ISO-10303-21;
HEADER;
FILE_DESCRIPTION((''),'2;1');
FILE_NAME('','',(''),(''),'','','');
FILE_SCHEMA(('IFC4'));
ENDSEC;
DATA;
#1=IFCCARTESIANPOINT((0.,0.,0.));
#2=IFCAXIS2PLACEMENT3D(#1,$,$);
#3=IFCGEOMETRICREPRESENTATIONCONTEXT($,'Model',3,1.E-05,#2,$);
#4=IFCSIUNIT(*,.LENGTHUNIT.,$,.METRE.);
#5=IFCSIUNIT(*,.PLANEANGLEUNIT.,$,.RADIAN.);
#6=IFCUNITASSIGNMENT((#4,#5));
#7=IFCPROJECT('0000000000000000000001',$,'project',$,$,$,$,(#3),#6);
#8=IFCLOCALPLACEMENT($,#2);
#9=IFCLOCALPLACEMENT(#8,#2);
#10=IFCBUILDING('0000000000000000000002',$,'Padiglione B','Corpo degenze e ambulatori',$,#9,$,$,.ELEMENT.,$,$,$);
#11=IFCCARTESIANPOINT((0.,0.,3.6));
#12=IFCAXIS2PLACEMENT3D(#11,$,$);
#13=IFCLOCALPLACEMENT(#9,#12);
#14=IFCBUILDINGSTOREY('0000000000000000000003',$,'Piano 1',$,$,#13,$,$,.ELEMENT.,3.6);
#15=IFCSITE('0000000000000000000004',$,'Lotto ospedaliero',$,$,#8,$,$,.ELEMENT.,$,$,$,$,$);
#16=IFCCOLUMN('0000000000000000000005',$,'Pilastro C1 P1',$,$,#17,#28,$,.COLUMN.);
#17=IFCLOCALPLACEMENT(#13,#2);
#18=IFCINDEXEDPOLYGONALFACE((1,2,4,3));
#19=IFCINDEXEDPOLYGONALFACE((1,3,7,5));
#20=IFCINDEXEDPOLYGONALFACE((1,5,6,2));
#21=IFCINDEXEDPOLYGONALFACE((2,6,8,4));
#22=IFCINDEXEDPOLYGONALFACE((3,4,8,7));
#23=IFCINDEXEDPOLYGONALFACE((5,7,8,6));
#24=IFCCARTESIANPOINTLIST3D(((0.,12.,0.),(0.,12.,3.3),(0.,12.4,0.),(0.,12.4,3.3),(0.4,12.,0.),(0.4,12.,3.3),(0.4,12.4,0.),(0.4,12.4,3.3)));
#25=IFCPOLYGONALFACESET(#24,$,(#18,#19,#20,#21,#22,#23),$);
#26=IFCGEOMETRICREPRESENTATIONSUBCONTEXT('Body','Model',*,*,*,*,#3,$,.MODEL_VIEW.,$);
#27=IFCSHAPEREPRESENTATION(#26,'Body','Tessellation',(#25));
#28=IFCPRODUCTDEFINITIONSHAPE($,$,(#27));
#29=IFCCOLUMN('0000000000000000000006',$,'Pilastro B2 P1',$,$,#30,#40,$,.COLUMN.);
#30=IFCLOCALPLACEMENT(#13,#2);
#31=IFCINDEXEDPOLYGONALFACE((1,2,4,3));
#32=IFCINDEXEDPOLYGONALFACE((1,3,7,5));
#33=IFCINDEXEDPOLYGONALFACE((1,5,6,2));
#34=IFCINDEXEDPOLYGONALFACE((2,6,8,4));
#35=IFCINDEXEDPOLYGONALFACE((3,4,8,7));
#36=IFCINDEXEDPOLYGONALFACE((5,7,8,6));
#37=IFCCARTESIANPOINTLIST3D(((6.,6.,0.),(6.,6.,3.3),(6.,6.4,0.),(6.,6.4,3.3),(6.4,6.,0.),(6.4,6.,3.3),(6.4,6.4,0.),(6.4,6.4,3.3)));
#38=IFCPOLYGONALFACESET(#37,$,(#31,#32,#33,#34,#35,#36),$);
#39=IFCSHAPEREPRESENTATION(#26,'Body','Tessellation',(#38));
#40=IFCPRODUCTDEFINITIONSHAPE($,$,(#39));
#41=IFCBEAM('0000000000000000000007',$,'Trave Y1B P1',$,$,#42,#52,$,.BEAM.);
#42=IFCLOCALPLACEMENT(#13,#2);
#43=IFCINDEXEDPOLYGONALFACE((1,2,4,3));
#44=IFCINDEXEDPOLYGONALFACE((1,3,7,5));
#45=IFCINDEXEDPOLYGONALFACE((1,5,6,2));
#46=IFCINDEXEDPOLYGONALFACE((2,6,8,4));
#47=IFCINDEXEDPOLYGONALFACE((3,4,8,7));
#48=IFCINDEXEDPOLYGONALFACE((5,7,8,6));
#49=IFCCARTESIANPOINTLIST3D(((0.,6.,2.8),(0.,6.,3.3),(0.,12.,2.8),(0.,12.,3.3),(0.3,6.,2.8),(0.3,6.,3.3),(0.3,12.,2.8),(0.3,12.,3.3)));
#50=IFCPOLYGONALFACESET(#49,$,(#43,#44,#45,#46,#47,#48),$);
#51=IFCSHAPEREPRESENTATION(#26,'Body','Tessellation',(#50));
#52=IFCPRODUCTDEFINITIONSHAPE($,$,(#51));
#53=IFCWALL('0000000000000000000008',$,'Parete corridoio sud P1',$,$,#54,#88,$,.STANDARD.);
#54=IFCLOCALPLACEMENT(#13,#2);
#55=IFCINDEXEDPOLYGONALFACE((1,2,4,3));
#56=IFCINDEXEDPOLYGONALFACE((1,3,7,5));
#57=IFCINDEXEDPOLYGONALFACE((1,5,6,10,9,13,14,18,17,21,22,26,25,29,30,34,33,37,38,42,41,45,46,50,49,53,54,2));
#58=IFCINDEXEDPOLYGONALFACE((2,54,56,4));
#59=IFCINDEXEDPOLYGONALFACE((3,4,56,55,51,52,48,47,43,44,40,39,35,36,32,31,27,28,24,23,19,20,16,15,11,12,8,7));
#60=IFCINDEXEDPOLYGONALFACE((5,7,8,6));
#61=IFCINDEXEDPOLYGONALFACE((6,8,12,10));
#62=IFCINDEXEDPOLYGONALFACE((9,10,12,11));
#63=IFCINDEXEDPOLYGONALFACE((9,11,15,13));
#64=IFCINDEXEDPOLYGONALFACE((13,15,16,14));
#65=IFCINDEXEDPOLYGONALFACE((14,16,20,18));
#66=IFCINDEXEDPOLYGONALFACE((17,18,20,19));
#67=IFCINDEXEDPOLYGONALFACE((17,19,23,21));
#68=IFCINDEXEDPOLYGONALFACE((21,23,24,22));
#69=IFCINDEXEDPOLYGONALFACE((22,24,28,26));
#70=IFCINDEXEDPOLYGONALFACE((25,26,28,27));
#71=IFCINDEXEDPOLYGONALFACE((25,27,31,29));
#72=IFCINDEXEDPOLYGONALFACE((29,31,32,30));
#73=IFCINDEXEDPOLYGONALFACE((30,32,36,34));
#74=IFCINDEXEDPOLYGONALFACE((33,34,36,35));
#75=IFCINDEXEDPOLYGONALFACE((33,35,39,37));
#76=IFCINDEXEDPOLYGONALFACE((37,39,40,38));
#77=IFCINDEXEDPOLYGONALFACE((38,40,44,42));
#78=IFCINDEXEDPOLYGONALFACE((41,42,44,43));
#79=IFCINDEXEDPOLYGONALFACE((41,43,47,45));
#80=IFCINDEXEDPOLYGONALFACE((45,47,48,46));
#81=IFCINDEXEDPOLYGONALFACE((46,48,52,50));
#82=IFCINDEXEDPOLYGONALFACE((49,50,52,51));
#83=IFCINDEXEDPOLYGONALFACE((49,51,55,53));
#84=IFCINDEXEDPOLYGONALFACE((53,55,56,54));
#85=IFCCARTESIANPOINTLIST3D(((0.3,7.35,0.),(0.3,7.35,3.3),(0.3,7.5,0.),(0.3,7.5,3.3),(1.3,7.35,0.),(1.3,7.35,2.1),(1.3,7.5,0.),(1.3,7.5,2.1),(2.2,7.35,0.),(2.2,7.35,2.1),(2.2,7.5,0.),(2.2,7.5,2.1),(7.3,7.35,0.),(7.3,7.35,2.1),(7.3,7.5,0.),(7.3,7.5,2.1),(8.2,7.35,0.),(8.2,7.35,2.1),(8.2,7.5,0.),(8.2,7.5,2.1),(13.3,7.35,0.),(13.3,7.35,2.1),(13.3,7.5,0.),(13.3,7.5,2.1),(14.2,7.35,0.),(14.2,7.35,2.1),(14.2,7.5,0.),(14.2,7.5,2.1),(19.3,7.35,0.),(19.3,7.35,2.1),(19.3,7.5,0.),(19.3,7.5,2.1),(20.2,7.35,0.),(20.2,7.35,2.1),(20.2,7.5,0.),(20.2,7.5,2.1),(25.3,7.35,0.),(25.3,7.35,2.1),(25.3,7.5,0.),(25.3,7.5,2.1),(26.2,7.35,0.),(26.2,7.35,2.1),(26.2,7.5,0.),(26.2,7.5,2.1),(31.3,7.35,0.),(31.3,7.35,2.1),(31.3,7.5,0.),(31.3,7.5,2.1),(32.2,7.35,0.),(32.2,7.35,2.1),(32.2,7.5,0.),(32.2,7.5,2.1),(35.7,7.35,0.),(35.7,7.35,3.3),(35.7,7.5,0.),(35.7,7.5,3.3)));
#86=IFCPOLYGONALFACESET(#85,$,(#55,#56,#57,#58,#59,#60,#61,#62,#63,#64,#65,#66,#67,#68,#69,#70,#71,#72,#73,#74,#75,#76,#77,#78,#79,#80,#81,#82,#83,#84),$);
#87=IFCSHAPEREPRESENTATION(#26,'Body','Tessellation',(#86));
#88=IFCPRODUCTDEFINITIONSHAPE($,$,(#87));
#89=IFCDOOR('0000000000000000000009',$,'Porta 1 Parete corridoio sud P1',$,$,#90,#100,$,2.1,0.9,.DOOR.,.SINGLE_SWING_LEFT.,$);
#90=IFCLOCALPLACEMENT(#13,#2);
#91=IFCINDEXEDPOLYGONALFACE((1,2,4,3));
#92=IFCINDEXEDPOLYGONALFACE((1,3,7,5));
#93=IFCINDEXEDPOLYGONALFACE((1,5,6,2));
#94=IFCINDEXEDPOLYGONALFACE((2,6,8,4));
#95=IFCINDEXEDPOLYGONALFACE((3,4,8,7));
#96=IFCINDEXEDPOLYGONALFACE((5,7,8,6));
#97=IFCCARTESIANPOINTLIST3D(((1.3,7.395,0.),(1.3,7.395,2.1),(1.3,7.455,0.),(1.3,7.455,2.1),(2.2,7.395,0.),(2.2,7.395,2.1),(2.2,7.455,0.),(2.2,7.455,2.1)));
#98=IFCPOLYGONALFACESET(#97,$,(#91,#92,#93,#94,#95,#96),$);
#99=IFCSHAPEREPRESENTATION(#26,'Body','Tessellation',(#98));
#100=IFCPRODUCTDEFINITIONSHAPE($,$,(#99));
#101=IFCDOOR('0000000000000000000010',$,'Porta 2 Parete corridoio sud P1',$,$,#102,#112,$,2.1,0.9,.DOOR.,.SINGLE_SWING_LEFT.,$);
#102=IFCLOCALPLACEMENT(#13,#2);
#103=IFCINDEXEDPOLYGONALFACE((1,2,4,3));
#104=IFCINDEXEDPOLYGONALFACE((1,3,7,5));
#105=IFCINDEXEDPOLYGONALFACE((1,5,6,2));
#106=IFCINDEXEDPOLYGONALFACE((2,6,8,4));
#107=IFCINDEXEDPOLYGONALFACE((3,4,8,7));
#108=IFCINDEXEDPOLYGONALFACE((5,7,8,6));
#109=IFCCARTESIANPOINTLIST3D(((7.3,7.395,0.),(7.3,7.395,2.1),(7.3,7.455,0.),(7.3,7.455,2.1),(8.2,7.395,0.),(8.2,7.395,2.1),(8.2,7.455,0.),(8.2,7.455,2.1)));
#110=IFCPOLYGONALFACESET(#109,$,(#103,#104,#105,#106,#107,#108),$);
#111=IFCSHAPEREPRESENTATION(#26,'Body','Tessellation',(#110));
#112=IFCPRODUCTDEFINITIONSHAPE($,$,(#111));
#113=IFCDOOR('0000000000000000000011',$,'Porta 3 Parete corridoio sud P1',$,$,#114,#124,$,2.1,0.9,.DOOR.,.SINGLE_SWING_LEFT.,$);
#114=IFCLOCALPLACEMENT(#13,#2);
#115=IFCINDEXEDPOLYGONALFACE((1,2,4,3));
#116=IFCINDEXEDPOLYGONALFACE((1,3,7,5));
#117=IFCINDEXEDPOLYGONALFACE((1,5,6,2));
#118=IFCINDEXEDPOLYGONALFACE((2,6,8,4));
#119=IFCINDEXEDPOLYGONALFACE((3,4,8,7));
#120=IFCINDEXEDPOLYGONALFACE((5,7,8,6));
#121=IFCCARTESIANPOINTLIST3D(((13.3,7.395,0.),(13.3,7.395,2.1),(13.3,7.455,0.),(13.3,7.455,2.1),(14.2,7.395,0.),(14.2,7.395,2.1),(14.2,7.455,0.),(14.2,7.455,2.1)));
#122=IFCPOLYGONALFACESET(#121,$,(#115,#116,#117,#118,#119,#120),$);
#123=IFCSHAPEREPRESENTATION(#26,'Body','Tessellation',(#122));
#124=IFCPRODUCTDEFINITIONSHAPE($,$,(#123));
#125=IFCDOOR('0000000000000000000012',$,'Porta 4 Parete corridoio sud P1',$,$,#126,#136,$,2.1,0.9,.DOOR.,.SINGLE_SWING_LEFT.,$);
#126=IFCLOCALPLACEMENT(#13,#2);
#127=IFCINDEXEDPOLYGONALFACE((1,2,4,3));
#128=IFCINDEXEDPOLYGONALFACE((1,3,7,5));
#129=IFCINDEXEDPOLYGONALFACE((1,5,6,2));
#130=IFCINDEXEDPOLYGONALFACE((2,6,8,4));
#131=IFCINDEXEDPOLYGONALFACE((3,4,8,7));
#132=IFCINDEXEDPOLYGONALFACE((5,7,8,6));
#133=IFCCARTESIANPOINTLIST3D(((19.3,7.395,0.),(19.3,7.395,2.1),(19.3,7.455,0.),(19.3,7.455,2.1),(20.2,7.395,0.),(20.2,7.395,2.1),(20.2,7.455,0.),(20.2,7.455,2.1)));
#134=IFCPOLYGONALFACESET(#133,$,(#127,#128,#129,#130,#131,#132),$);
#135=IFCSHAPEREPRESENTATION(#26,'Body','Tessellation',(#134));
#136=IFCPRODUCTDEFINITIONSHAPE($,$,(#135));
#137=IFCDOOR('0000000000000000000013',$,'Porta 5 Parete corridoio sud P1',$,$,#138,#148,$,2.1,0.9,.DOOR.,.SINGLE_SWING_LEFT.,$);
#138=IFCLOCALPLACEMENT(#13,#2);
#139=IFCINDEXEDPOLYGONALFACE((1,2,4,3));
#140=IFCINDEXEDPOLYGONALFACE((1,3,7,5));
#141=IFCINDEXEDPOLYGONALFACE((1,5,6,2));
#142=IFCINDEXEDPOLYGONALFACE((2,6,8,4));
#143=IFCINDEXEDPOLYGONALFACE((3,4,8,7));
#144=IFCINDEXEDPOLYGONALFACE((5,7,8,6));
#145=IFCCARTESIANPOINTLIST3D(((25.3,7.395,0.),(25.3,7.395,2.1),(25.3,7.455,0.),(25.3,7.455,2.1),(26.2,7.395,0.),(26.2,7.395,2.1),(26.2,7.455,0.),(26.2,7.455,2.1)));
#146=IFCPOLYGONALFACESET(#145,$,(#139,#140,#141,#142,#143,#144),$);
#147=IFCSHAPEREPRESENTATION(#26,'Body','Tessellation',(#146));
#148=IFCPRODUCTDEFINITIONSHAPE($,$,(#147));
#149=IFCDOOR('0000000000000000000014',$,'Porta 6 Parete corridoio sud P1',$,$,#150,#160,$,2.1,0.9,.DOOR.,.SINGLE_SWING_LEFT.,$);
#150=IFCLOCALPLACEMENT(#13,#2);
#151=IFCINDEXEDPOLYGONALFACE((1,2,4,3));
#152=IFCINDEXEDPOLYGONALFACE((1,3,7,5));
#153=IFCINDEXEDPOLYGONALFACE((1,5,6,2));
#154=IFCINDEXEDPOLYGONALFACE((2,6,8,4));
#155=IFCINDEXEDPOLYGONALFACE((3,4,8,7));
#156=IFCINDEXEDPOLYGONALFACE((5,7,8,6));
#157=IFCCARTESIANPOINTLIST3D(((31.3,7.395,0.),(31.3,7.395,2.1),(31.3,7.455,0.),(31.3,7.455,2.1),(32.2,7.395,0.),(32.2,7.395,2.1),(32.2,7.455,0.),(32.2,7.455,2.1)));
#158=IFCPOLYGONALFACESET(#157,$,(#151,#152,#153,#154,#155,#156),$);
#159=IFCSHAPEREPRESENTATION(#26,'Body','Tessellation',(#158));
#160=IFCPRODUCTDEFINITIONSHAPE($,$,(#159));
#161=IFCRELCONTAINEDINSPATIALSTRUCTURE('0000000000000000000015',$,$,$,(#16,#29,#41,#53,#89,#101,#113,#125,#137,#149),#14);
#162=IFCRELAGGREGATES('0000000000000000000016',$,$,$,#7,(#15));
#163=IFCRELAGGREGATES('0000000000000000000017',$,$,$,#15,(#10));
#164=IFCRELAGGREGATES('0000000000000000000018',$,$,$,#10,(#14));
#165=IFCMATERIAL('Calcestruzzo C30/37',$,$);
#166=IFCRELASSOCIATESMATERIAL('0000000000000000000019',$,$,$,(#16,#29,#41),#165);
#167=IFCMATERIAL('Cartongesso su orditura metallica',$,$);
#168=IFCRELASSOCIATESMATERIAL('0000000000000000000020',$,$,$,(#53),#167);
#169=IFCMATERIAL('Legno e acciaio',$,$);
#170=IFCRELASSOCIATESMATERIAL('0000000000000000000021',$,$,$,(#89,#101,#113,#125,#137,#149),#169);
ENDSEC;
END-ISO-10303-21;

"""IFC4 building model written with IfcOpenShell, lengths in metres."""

from ifc_helpers import new_model, si_unit, frame, frame_2d, origin, place, context, subcontext, project, spatial, rectangle, extrude, material, element, fill, save


model = new_model("IFC4")

# Units and contexts
model_context = context("Model", 3, precision=1e-05, world=origin())
body_context = subcontext(model_context, "Body", "Model", "MODEL_VIEW")
ifc_project = project(units=[si_unit("LENGTHUNIT", "METRE"), si_unit("PLANEANGLEUNIT", "RADIAN")], contexts=[model_context])

# Site, building, storey
site_placement = place(None, origin())
site = spatial("IfcSite", under=ifc_project, at=site_placement, Name="Lotto ospedaliero", CompositionType="ELEMENT")
building_placement = place(site_placement, origin())
building = spatial("IfcBuilding", under=site, at=building_placement, Name="Padiglione B", Description="Corpo degenze e ambulatori", CompositionType="ELEMENT")
storey_placement = place(building_placement, frame((0.0, 0.0, 3.6)))
storey = spatial("IfcBuildingStorey", under=building, at=storey_placement, Name="Piano 1", CompositionType="ELEMENT", Elevation=3.6)

# Columns
ifc_material_1 = material(Name="Calcestruzzo C30/37")
for number, where, name in (
    (1, (0.0, 12.0, 0.0), "Pilastro C1 P1"),
    (2, (6.0, 6.0, 0.0), "Pilastro B2 P1"),
):
    element("IfcColumn", number, at=place(storey_placement, frame(where)), inside=storey, material=ifc_material_1, Name=name, PredefinedType="COLUMN", context=body_context, shape_type="SweptSolid", body=[
        extrude(rectangle(XDim=0.4, YDim=0.4, at=frame_2d((0.2, 0.2))), origin(), (0.0, 0.0, 1.0), 3.3),
    ])

# Beam
beam_placement = place(storey_placement, frame((0.0, 6.0, 2.8)))
element("IfcBeam", 3, at=beam_placement, inside=storey, material=ifc_material_1, Name="Trave Y1B P1", PredefinedType="BEAM", context=body_context, shape_type="SweptSolid", body=[
    extrude(rectangle(XDim=0.3, YDim=6.0, at=frame_2d((0.15, 3.0))), origin(), (0.0, 0.0, 1.0), 0.5),
])

# Wall, openings, doors
ifc_material_2 = material(Name="Cartongesso su orditura metallica")
wall_1_placement = place(storey_placement, frame((0.3, 7.35, 0.0)))
wall_1 = element("IfcWall", 4, at=wall_1_placement, inside=storey, material=ifc_material_2, Name="Parete corridoio sud P1", PredefinedType="STANDARD", context=body_context, shape_type="SweptSolid", body=[
    extrude(rectangle(XDim=35.4, YDim=0.15, at=frame_2d((17.7, 0.075))), origin(), (0.0, 0.0, 1.0), 3.3),
])
opening_1_placement = place(wall_1_placement, frame((1.0, -0.1, 0.0)))
opening_1 = element("IfcOpeningElement", 5, at=opening_1_placement, cuts=wall_1, PredefinedType="OPENING", context=body_context, shape_type="SweptSolid", body=[
    extrude(rectangle(XDim=0.9, YDim=0.35, at=frame_2d((0.45, 0.175))), origin(), (0.0, 0.0, 1.0), 2.1),
])
opening_2_placement = place(wall_1_placement, frame((7.0, -0.1, 0.0)))
opening_2 = element("IfcOpeningElement", 6, at=opening_2_placement, cuts=wall_1, PredefinedType="OPENING", context=body_context, shape_type="SweptSolid", body=[
    extrude(rectangle(XDim=0.9, YDim=0.35, at=frame_2d((0.45, 0.175))), origin(), (0.0, 0.0, 1.0), 2.1),
])
opening_3_placement = place(wall_1_placement, frame((13.0, -0.1, 0.0)))
opening_3 = element("IfcOpeningElement", 7, at=opening_3_placement, cuts=wall_1, PredefinedType="OPENING", context=body_context, shape_type="SweptSolid", body=[
    extrude(rectangle(XDim=0.9, YDim=0.35, at=frame_2d((0.45, 0.175))), origin(), (0.0, 0.0, 1.0), 2.1),
])
opening_4_placement = place(wall_1_placement, frame((19.0, -0.1, 0.0)))
opening_4 = element("IfcOpeningElement", 8, at=opening_4_placement, cuts=wall_1, PredefinedType="OPENING", context=body_context, shape_type="SweptSolid", body=[
    extrude(rectangle(XDim=0.9, YDim=0.35, at=frame_2d((0.45, 0.175))), origin(), (0.0, 0.0, 1.0), 2.1),
])
opening_5_placement = place(wall_1_placement, frame((25.0, -0.1, 0.0)))
opening_5 = element("IfcOpeningElement", 9, at=opening_5_placement, cuts=wall_1, PredefinedType="OPENING", context=body_context, shape_type="SweptSolid", body=[
    extrude(rectangle(XDim=0.9, YDim=0.35, at=frame_2d((0.45, 0.175))), origin(), (0.0, 0.0, 1.0), 2.1),
])
opening_6_placement = place(wall_1_placement, frame((31.0, -0.1, 0.0)))
opening_6 = element("IfcOpeningElement", 10, at=opening_6_placement, cuts=wall_1, PredefinedType="OPENING", context=body_context, shape_type="SweptSolid", body=[
    extrude(rectangle(XDim=0.9, YDim=0.35, at=frame_2d((0.45, 0.175))), origin(), (0.0, 0.0, 1.0), 2.1),
])
ifc_material_3 = material(Name="Legno e acciaio")
door_1_placement = place(wall_1_placement, frame((1.0, 0.045, 0.0)))
door_1 = element("IfcDoor", 11, at=door_1_placement, inside=storey, material=ifc_material_3, Name="Porta 1 Parete corridoio sud P1", OperationType="SINGLE_SWING_LEFT", OverallHeight=2.1, OverallWidth=0.9, PredefinedType="DOOR", context=body_context, shape_type="SweptSolid", body=[
    extrude(rectangle(XDim=0.9, YDim=0.06, at=frame_2d((0.45, 0.03))), origin(), (0.0, 0.0, 1.0), 2.1),
])
fill(opening_1, door_1)
door_2_placement = place(wall_1_placement, frame((7.0, 0.045, 0.0)))
door_2 = element("IfcDoor", 12, at=door_2_placement, inside=storey, material=ifc_material_3, Name="Porta 2 Parete corridoio sud P1", OperationType="SINGLE_SWING_LEFT", OverallHeight=2.1, OverallWidth=0.9, PredefinedType="DOOR", context=body_context, shape_type="SweptSolid", body=[
    extrude(rectangle(XDim=0.9, YDim=0.06, at=frame_2d((0.45, 0.03))), origin(), (0.0, 0.0, 1.0), 2.1),
])
fill(opening_2, door_2)
door_3_placement = place(wall_1_placement, frame((13.0, 0.045, 0.0)))
door_3 = element("IfcDoor", 13, at=door_3_placement, inside=storey, material=ifc_material_3, Name="Porta 3 Parete corridoio sud P1", OperationType="SINGLE_SWING_LEFT", OverallHeight=2.1, OverallWidth=0.9, PredefinedType="DOOR", context=body_context, shape_type="SweptSolid", body=[
    extrude(rectangle(XDim=0.9, YDim=0.06, at=frame_2d((0.45, 0.03))), origin(), (0.0, 0.0, 1.0), 2.1),
])
fill(opening_3, door_3)
door_4_placement = place(wall_1_placement, frame((19.0, 0.045, 0.0)))
door_4 = element("IfcDoor", 14, at=door_4_placement, inside=storey, material=ifc_material_3, Name="Porta 4 Parete corridoio sud P1", OperationType="SINGLE_SWING_LEFT", OverallHeight=2.1, OverallWidth=0.9, PredefinedType="DOOR", context=body_context, shape_type="SweptSolid", body=[
    extrude(rectangle(XDim=0.9, YDim=0.06, at=frame_2d((0.45, 0.03))), origin(), (0.0, 0.0, 1.0), 2.1),
])
fill(opening_4, door_4)
door_5_placement = place(wall_1_placement, frame((25.0, 0.045, 0.0)))
door_5 = element("IfcDoor", 15, at=door_5_placement, inside=storey, material=ifc_material_3, Name="Porta 5 Parete corridoio sud P1", OperationType="SINGLE_SWING_LEFT", OverallHeight=2.1, OverallWidth=0.9, PredefinedType="DOOR", context=body_context, shape_type="SweptSolid", body=[
    extrude(rectangle(XDim=0.9, YDim=0.06, at=frame_2d((0.45, 0.03))), origin(), (0.0, 0.0, 1.0), 2.1),
])
fill(opening_5, door_5)
door_6_placement = place(wall_1_placement, frame((31.0, 0.045, 0.0)))
door_6 = element("IfcDoor", 16, at=door_6_placement, inside=storey, material=ifc_material_3, Name="Porta 6 Parete corridoio sud P1", OperationType="SINGLE_SWING_LEFT", OverallHeight=2.1, OverallWidth=0.9, PredefinedType="DOOR", context=body_context, shape_type="SweptSolid", body=[
    extrude(rectangle(XDim=0.9, YDim=0.06, at=frame_2d((0.45, 0.03))), origin(), (0.0, 0.0, 1.0), 2.1),
])
fill(opening_6, door_6)

save(model, "model.ifc")
